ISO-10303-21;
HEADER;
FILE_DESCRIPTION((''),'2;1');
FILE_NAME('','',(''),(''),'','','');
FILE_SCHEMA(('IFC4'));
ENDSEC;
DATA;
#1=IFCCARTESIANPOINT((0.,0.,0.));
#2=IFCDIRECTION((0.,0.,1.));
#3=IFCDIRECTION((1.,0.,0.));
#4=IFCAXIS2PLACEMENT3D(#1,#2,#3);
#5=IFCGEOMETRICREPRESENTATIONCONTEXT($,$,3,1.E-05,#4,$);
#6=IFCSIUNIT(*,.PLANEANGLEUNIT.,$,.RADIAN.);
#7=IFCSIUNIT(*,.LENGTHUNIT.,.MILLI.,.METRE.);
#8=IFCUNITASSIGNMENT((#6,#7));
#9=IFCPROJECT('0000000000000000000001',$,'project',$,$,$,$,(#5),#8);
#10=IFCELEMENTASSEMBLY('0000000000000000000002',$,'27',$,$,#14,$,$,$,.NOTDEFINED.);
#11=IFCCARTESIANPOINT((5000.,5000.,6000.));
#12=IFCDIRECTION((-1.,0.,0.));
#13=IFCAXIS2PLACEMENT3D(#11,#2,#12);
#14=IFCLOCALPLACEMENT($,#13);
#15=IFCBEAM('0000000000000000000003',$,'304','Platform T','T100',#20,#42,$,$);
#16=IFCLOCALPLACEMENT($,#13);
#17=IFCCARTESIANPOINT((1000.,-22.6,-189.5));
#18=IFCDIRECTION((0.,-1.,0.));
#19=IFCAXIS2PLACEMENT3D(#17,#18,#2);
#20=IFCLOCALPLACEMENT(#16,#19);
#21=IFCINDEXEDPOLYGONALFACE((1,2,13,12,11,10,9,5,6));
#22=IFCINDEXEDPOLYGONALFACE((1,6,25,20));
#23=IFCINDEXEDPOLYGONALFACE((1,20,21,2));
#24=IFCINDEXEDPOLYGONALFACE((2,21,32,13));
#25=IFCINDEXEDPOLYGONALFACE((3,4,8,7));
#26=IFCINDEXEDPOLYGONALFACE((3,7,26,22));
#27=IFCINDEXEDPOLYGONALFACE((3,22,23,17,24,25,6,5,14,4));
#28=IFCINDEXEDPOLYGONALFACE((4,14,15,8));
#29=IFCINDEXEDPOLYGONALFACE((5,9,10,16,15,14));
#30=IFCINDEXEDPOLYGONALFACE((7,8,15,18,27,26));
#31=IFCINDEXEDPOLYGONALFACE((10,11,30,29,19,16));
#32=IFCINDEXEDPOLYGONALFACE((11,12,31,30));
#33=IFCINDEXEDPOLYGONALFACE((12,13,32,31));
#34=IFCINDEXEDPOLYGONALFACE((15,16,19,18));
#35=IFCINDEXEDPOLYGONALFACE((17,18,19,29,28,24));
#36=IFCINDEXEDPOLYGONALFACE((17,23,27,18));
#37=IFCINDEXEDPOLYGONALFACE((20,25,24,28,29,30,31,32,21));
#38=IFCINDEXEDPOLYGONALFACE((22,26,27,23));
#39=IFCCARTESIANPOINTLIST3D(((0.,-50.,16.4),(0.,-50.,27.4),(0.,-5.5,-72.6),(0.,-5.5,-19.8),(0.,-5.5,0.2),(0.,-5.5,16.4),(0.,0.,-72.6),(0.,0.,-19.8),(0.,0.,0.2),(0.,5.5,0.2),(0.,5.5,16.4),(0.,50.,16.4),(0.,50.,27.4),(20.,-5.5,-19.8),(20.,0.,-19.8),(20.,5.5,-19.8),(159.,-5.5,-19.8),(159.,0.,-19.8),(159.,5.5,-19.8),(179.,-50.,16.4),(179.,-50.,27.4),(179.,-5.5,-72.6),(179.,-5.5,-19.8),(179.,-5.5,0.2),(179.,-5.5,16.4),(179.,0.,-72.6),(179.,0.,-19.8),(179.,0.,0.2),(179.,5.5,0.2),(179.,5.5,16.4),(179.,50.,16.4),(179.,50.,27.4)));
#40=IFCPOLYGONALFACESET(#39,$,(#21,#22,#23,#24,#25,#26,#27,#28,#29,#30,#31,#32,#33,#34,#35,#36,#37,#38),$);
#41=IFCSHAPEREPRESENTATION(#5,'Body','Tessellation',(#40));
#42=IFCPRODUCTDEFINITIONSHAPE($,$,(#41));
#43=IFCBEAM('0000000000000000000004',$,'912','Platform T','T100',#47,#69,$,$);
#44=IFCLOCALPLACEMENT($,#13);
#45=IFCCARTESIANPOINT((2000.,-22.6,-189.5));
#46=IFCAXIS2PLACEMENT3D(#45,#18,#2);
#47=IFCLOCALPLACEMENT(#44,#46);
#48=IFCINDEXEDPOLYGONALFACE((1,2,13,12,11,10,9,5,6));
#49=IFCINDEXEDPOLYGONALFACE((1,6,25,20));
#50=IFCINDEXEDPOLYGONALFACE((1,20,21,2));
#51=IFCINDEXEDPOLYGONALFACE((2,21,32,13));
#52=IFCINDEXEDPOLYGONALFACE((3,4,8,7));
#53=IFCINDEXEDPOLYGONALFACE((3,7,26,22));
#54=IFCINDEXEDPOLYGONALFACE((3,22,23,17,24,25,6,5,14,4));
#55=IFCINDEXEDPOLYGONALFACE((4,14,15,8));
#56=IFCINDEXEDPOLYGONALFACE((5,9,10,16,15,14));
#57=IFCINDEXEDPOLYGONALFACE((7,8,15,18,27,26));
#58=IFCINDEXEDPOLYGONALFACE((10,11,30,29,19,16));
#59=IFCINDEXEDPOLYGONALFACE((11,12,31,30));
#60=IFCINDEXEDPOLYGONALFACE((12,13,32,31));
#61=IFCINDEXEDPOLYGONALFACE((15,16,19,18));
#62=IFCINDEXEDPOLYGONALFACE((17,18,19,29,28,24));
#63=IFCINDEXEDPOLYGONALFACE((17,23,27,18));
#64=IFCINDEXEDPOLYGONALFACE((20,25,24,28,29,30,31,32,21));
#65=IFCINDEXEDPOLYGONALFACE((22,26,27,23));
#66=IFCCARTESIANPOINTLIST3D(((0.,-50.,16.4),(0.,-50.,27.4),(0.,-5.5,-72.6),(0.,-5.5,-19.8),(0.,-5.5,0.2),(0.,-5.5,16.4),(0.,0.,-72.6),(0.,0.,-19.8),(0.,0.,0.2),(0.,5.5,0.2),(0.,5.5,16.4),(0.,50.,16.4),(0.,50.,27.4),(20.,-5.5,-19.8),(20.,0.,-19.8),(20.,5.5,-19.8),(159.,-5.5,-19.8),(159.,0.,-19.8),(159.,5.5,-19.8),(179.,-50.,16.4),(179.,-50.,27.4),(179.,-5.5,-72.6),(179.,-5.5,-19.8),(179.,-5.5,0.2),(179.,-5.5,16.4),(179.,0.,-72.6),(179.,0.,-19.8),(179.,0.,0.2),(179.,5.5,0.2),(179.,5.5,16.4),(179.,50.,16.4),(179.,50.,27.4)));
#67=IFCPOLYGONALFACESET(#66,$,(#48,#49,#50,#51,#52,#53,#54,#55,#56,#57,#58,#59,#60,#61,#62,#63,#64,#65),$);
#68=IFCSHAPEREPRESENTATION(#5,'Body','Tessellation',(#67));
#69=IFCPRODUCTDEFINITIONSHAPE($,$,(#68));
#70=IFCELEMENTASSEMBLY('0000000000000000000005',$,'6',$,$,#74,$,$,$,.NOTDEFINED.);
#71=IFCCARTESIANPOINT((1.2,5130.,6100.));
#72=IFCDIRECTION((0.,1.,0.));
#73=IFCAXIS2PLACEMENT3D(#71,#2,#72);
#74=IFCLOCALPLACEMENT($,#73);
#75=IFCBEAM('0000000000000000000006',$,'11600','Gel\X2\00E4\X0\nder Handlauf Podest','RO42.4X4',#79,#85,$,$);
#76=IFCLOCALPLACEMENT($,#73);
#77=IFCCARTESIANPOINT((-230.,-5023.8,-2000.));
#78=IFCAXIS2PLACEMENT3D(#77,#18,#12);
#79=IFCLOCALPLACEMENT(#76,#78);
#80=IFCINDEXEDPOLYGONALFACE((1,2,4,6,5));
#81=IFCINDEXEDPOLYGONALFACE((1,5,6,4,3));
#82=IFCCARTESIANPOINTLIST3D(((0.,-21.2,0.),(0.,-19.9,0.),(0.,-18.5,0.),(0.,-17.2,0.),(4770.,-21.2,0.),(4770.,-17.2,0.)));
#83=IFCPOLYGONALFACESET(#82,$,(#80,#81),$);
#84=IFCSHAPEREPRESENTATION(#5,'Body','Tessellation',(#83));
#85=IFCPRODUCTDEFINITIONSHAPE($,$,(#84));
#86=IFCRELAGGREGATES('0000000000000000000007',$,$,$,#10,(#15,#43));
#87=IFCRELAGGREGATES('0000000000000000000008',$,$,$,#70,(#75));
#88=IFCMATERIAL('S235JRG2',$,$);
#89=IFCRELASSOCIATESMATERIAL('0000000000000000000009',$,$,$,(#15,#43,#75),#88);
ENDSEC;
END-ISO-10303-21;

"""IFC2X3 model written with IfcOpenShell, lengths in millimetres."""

from ifc_helpers import new_model, si_unit, point, frame, origin_with_axes, place, context, project, polyline, line_curve, trimmed, segment, composite_curve, outline, extrude, material, element, aggregate, save


model = new_model("IFC2X3")

# Units and contexts
context_of_model = context(None, 3, precision=1e-05, world=origin_with_axes())
ifc_project = project(units=[si_unit("PLANEANGLEUNIT", "RADIAN"), si_unit("LENGTHUNIT", "METRE", prefix="MILLI")], contexts=[context_of_model])

# Element assemblies, beams, openings
assembly_1_placement = place(None, frame((5000.0, 5000.0, 6000.0), z_axis=(0.0, 0.0, 1.0), x_axis=(-1.0, 0.0, 0.0)))
assembly_1 = element("IfcElementAssembly", 1, at=assembly_1_placement, Name="27", PredefinedType="NOTDEFINED")
ifc_material = material(Name="S235JRG2")
placement_1 = place(None, frame((5000.0, 5000.0, 6000.0), z_axis=(0.0, 0.0, 1.0), x_axis=(-1.0, 0.0, 0.0)))
beam_1_placement = place(placement_1, frame((1000.0, -22.6, -189.5), z_axis=(0.0, -1.0, 0.0), x_axis=(0.0, 0.0, 1.0)))
beam_1 = element("IfcBeam", 2, at=beam_1_placement, material=ifc_material, Name="304", Description="Platform T", ObjectType="T100", context=context_of_model, shape_type="SweptSolid", body=[
    extrude(outline(polyline([(5.5, -72.6), (5.5, 16.4), (50.0, 16.4), (50.0, 27.4), (-50.0, 27.4), (-50.0, 16.4), (-5.5, 16.4), (-5.5, -72.6), (5.5, -72.6), (5.5, -72.6)])), frame((0.0, 0.0, 0.0), z_axis=(1.0, 0.0, 0.0), x_axis=(0.0, 1.0, 0.0)), (0.0, 0.0, 1.0), 179.0),
])
opening_1_placement = place(beam_1_placement, frame((179.0, 0.0, -72.6), z_axis=(0.0, 1.0, 0.0), x_axis=(0.0, 0.0, 1.0)))
element("IfcOpeningElement", 3, at=opening_1_placement, cuts=beam_1, ObjectType="Recess", context=context_of_model, shape_type="SweptSolid", body=[
    extrude(outline(composite_curve([segment(trimmed(line_curve((0.0, 0.0), (0.0, -1.0, 0.0), 179.0), [point((0.0, 0.0))], [point((0.0, -179.0))], True, "CARTESIAN"), True, "CONTINUOUS"), segment(trimmed(line_curve((0.0, -179.0), (1.0, 0.0, 0.0), 52.8), [point((0.0, -179.0))], [point((52.8, -179.0))], True, "CARTESIAN"), True, "CONTINUOUS"), segment(trimmed(line_curve((52.8, -179.0), (0.0, 1.0, 0.0), 179.0), [point((52.8, -179.0))], [point((52.8, 0.0))], True, "CARTESIAN"), True, "CONTINUOUS"), segment(trimmed(line_curve((52.8, 0.0), (-1.0, 0.0, 0.0), 52.8), [point((52.8, 0.0))], [point((0.0, 0.0))], True, "CARTESIAN"), True, "CONTINUOUS")], self_intersect=False)), origin_with_axes(), (0.0, 0.0, 1.0), 100.0),
])
opening_2_placement = place(beam_1_placement, frame((179.0, 0.0, -19.8), z_axis=(0.0, 1.0, 0.0), x_axis=(0.0, 0.0, 1.0)))
element("IfcOpeningElement", 4, at=opening_2_placement, cuts=beam_1, context=context_of_model, shape_type="SweptSolid", body=[
    extrude(outline(composite_curve([segment(trimmed(line_curve((0.0, 0.0), (1.0, 0.0, 0.0), 20.0), [point((0.0, 0.0))], [point((20.0, 0.0))], True, "CARTESIAN"), True, "CONTINUOUS"), segment(trimmed(line_curve((20.0, 0.0), (-0.707107, -0.707107, 0.0), 28.284271), [point((20.0, 0.0))], [point((0.0, -20.0))], True, "CARTESIAN"), True, "CONTINUOUS"), segment(trimmed(line_curve((0.0, -20.0), (0.0, 1.0, 0.0), 20.0), [point((0.0, -20.0))], [point((0.0, 0.0))], True, "CARTESIAN"), True, "CONTINUOUS")], self_intersect=False)), origin_with_axes(), (0.0, 0.0, 1.0), 100.0),
])
opening_3_placement = place(beam_1_placement, frame((179.0, 0.0, -19.8), z_axis=(0.0, -1.0, 0.0), x_axis=(0.0, 0.0, -1.0)))
element("IfcOpeningElement", 5, at=opening_3_placement, cuts=beam_1, context=context_of_model, shape_type="SweptSolid", body=[
    extrude(outline(composite_curve([segment(trimmed(line_curve((0.0, 0.0), (-1.0, 0.0, 0.0), 20.0), [point((0.0, 0.0))], [point((-20.0, 0.0))], True, "CARTESIAN"), True, "CONTINUOUS"), segment(trimmed(line_curve((-20.0, 0.0), (0.707107, -0.707107, 0.0), 28.284271), [point((-20.0, 0.0))], [point((0.0, -20.0))], True, "CARTESIAN"), True, "CONTINUOUS"), segment(trimmed(line_curve((0.0, -20.0), (0.0, 1.0, 0.0), 20.0), [point((0.0, -20.0))], [point((0.0, 0.0))], True, "CARTESIAN"), True, "CONTINUOUS")], self_intersect=False)), origin_with_axes(), (0.0, 0.0, 1.0), 100.0),
])
opening_4_placement = place(beam_1_placement, frame((0.0, 0.0, -19.8), z_axis=(0.0, -1.0, 0.0), x_axis=(0.0, 0.0, -1.0)))
element("IfcOpeningElement", 6, at=opening_4_placement, cuts=beam_1, context=context_of_model, shape_type="SweptSolid", body=[
    extrude(outline(composite_curve([segment(trimmed(line_curve((0.0, 0.0), (-1.0, 0.0, 0.0), 20.0), [point((0.0, 0.0))], [point((-20.0, 0.0))], True, "CARTESIAN"), True, "CONTINUOUS"), segment(trimmed(line_curve((-20.0, 0.0), (0.707107, 0.707107, 0.0), 28.284271), [point((-20.0, 0.0))], [point((0.0, 20.0))], True, "CARTESIAN"), True, "CONTINUOUS"), segment(trimmed(line_curve((0.0, 20.0), (0.0, -1.0, 0.0), 20.0), [point((0.0, 20.0))], [point((0.0, 0.0))], True, "CARTESIAN"), True, "CONTINUOUS")], self_intersect=False)), origin_with_axes(), (0.0, 0.0, 1.0), 100.0),
])
opening_5_placement = place(beam_1_placement, frame((0.0, 0.0, -19.8), z_axis=(0.0, 1.0, 0.0), x_axis=(0.0, 0.0, 1.0)))
element("IfcOpeningElement", 7, at=opening_5_placement, cuts=beam_1, context=context_of_model, shape_type="SweptSolid", body=[
    extrude(outline(composite_curve([segment(trimmed(line_curve((0.0, 0.0), (1.0, 0.0, 0.0), 20.0), [point((0.0, 0.0))], [point((20.0, 0.0))], True, "CARTESIAN"), True, "CONTINUOUS"), segment(trimmed(line_curve((20.0, 0.0), (-0.707107, 0.707107, 0.0), 28.284271), [point((20.0, 0.0))], [point((0.0, 20.0))], True, "CARTESIAN"), True, "CONTINUOUS"), segment(trimmed(line_curve((0.0, 20.0), (0.0, -1.0, 0.0), 20.0), [point((0.0, 20.0))], [point((0.0, 0.0))], True, "CARTESIAN"), True, "CONTINUOUS")], self_intersect=False)), origin_with_axes(), (0.0, 0.0, 1.0), 100.0),
])
placement_2 = place(None, frame((5000.0, 5000.0, 6000.0), z_axis=(0.0, 0.0, 1.0), x_axis=(-1.0, 0.0, 0.0)))
beam_2_placement = place(placement_2, frame((2000.0, -22.6, -189.5), z_axis=(0.0, -1.0, 0.0), x_axis=(0.0, 0.0, 1.0)))
beam_2 = element("IfcBeam", 8, at=beam_2_placement, material=ifc_material, Name="912", Description="Platform T", ObjectType="T100", context=context_of_model, shape_type="SweptSolid", body=[
    extrude(outline(polyline([(5.5, -72.6), (5.5, 16.4), (50.0, 16.4), (50.0, 27.4), (-50.0, 27.4), (-50.0, 16.4), (-5.5, 16.4), (-5.5, -72.6), (5.5, -72.6), (5.5, -72.6)])), frame((0.0, 0.0, 0.0), z_axis=(1.0, 0.0, 0.0), x_axis=(0.0, 1.0, 0.0)), (0.0, 0.0, 1.0), 179.0),
])
opening_6_placement = place(beam_2_placement, frame((179.0, 0.0, -72.6), z_axis=(0.0, 1.0, 0.0), x_axis=(0.0, 0.0, 1.0)))
element("IfcOpeningElement", 9, at=opening_6_placement, cuts=beam_2, ObjectType="Recess", context=context_of_model, shape_type="SweptSolid", body=[
    extrude(outline(composite_curve([segment(trimmed(line_curve((0.0, 0.0), (0.0, -1.0, 0.0), 179.0), [point((0.0, 0.0))], [point((0.0, -179.0))], True, "CARTESIAN"), True, "CONTINUOUS"), segment(trimmed(line_curve((0.0, -179.0), (1.0, 0.0, 0.0), 52.8), [point((0.0, -179.0))], [point((52.8, -179.0))], True, "CARTESIAN"), True, "CONTINUOUS"), segment(trimmed(line_curve((52.8, -179.0), (0.0, 1.0, 0.0), 179.0), [point((52.8, -179.0))], [point((52.8, 0.0))], True, "CARTESIAN"), True, "CONTINUOUS"), segment(trimmed(line_curve((52.8, 0.0), (-1.0, 0.0, 0.0), 52.8), [point((52.8, 0.0))], [point((0.0, 0.0))], True, "CARTESIAN"), True, "CONTINUOUS")], self_intersect=False)), origin_with_axes(), (0.0, 0.0, 1.0), 100.0),
])
opening_7_placement = place(beam_2_placement, frame((179.0, 0.0, -19.8), z_axis=(0.0, 1.0, 0.0), x_axis=(0.0, 0.0, 1.0)))
element("IfcOpeningElement", 10, at=opening_7_placement, cuts=beam_2, context=context_of_model, shape_type="SweptSolid", body=[
    extrude(outline(composite_curve([segment(trimmed(line_curve((0.0, 0.0), (1.0, 0.0, 0.0), 20.0), [point((0.0, 0.0))], [point((20.0, 0.0))], True, "CARTESIAN"), True, "CONTINUOUS"), segment(trimmed(line_curve((20.0, 0.0), (-0.707107, -0.707107, 0.0), 28.284271), [point((20.0, 0.0))], [point((0.0, -20.0))], True, "CARTESIAN"), True, "CONTINUOUS"), segment(trimmed(line_curve((0.0, -20.0), (0.0, 1.0, 0.0), 20.0), [point((0.0, -20.0))], [point((0.0, 0.0))], True, "CARTESIAN"), True, "CONTINUOUS")], self_intersect=False)), origin_with_axes(), (0.0, 0.0, 1.0), 100.0),
])
opening_8_placement = place(beam_2_placement, frame((179.0, 0.0, -19.8), z_axis=(0.0, -1.0, 0.0), x_axis=(0.0, 0.0, -1.0)))
element("IfcOpeningElement", 11, at=opening_8_placement, cuts=beam_2, context=context_of_model, shape_type="SweptSolid", body=[
    extrude(outline(composite_curve([segment(trimmed(line_curve((0.0, 0.0), (-1.0, 0.0, 0.0), 20.0), [point((0.0, 0.0))], [point((-20.0, 0.0))], True, "CARTESIAN"), True, "CONTINUOUS"), segment(trimmed(line_curve((-20.0, 0.0), (0.707107, -0.707107, 0.0), 28.284271), [point((-20.0, 0.0))], [point((0.0, -20.0))], True, "CARTESIAN"), True, "CONTINUOUS"), segment(trimmed(line_curve((0.0, -20.0), (0.0, 1.0, 0.0), 20.0), [point((0.0, -20.0))], [point((0.0, 0.0))], True, "CARTESIAN"), True, "CONTINUOUS")], self_intersect=False)), origin_with_axes(), (0.0, 0.0, 1.0), 100.0),
])
opening_9_placement = place(beam_2_placement, frame((0.0, 0.0, -19.8), z_axis=(0.0, -1.0, 0.0), x_axis=(0.0, 0.0, -1.0)))
element("IfcOpeningElement", 12, at=opening_9_placement, cuts=beam_2, context=context_of_model, shape_type="SweptSolid", body=[
    extrude(outline(composite_curve([segment(trimmed(line_curve((0.0, 0.0), (-1.0, 0.0, 0.0), 20.0), [point((0.0, 0.0))], [point((-20.0, 0.0))], True, "CARTESIAN"), True, "CONTINUOUS"), segment(trimmed(line_curve((-20.0, 0.0), (0.707107, 0.707107, 0.0), 28.284271), [point((-20.0, 0.0))], [point((0.0, 20.0))], True, "CARTESIAN"), True, "CONTINUOUS"), segment(trimmed(line_curve((0.0, 20.0), (0.0, -1.0, 0.0), 20.0), [point((0.0, 20.0))], [point((0.0, 0.0))], True, "CARTESIAN"), True, "CONTINUOUS")], self_intersect=False)), origin_with_axes(), (0.0, 0.0, 1.0), 100.0),
])
opening_10_placement = place(beam_2_placement, frame((0.0, 0.0, -19.8), z_axis=(0.0, 1.0, 0.0), x_axis=(0.0, 0.0, 1.0)))
element("IfcOpeningElement", 13, at=opening_10_placement, cuts=beam_2, context=context_of_model, shape_type="SweptSolid", body=[
    extrude(outline(composite_curve([segment(trimmed(line_curve((0.0, 0.0), (1.0, 0.0, 0.0), 20.0), [point((0.0, 0.0))], [point((20.0, 0.0))], True, "CARTESIAN"), True, "CONTINUOUS"), segment(trimmed(line_curve((20.0, 0.0), (-0.707107, 0.707107, 0.0), 28.284271), [point((20.0, 0.0))], [point((0.0, 20.0))], True, "CARTESIAN"), True, "CONTINUOUS"), segment(trimmed(line_curve((0.0, 20.0), (0.0, -1.0, 0.0), 20.0), [point((0.0, 20.0))], [point((0.0, 0.0))], True, "CARTESIAN"), True, "CONTINUOUS")], self_intersect=False)), origin_with_axes(), (0.0, 0.0, 1.0), 100.0),
])
aggregate(assembly_1, [beam_1, beam_2])
assembly_2_placement = place(None, frame((1.2, 5130.0, 6100.0), z_axis=(0.0, 0.0, 1.0), x_axis=(0.0, 1.0, 0.0)))
assembly_2 = element("IfcElementAssembly", 14, at=assembly_2_placement, Name="6", PredefinedType="NOTDEFINED")
placement_3 = place(None, frame((1.2, 5130.0, 6100.0), z_axis=(0.0, 0.0, 1.0), x_axis=(0.0, 1.0, 0.0)))
beam_3_placement = place(placement_3, frame((-230.0, -5023.8, -2000.0), z_axis=(0.0, -1.0, 0.0), x_axis=(-1.0, 0.0, 0.0)))
beam_3 = element("IfcBeam", 15, at=beam_3_placement, material=ifc_material, Name="11600", Description="Geländer Handlauf Podest", ObjectType="RO42.4X4", context=context_of_model, shape_type="SweptSolid", body=[
    extrude(outline(polyline([(-21.2, 0.0), (-21.2, 0.0), (-17.2, 0.0), (-17.2, 0.0), (-21.2, 0.0)])), frame((0.0, 0.0, 0.0), z_axis=(1.0, 0.0, 0.0), x_axis=(0.0, 1.0, 0.0)), (0.0, 0.0, 1.0), 4770.0),
])
aggregate(assembly_2, [beam_3])

save(model, "model.ifc")
